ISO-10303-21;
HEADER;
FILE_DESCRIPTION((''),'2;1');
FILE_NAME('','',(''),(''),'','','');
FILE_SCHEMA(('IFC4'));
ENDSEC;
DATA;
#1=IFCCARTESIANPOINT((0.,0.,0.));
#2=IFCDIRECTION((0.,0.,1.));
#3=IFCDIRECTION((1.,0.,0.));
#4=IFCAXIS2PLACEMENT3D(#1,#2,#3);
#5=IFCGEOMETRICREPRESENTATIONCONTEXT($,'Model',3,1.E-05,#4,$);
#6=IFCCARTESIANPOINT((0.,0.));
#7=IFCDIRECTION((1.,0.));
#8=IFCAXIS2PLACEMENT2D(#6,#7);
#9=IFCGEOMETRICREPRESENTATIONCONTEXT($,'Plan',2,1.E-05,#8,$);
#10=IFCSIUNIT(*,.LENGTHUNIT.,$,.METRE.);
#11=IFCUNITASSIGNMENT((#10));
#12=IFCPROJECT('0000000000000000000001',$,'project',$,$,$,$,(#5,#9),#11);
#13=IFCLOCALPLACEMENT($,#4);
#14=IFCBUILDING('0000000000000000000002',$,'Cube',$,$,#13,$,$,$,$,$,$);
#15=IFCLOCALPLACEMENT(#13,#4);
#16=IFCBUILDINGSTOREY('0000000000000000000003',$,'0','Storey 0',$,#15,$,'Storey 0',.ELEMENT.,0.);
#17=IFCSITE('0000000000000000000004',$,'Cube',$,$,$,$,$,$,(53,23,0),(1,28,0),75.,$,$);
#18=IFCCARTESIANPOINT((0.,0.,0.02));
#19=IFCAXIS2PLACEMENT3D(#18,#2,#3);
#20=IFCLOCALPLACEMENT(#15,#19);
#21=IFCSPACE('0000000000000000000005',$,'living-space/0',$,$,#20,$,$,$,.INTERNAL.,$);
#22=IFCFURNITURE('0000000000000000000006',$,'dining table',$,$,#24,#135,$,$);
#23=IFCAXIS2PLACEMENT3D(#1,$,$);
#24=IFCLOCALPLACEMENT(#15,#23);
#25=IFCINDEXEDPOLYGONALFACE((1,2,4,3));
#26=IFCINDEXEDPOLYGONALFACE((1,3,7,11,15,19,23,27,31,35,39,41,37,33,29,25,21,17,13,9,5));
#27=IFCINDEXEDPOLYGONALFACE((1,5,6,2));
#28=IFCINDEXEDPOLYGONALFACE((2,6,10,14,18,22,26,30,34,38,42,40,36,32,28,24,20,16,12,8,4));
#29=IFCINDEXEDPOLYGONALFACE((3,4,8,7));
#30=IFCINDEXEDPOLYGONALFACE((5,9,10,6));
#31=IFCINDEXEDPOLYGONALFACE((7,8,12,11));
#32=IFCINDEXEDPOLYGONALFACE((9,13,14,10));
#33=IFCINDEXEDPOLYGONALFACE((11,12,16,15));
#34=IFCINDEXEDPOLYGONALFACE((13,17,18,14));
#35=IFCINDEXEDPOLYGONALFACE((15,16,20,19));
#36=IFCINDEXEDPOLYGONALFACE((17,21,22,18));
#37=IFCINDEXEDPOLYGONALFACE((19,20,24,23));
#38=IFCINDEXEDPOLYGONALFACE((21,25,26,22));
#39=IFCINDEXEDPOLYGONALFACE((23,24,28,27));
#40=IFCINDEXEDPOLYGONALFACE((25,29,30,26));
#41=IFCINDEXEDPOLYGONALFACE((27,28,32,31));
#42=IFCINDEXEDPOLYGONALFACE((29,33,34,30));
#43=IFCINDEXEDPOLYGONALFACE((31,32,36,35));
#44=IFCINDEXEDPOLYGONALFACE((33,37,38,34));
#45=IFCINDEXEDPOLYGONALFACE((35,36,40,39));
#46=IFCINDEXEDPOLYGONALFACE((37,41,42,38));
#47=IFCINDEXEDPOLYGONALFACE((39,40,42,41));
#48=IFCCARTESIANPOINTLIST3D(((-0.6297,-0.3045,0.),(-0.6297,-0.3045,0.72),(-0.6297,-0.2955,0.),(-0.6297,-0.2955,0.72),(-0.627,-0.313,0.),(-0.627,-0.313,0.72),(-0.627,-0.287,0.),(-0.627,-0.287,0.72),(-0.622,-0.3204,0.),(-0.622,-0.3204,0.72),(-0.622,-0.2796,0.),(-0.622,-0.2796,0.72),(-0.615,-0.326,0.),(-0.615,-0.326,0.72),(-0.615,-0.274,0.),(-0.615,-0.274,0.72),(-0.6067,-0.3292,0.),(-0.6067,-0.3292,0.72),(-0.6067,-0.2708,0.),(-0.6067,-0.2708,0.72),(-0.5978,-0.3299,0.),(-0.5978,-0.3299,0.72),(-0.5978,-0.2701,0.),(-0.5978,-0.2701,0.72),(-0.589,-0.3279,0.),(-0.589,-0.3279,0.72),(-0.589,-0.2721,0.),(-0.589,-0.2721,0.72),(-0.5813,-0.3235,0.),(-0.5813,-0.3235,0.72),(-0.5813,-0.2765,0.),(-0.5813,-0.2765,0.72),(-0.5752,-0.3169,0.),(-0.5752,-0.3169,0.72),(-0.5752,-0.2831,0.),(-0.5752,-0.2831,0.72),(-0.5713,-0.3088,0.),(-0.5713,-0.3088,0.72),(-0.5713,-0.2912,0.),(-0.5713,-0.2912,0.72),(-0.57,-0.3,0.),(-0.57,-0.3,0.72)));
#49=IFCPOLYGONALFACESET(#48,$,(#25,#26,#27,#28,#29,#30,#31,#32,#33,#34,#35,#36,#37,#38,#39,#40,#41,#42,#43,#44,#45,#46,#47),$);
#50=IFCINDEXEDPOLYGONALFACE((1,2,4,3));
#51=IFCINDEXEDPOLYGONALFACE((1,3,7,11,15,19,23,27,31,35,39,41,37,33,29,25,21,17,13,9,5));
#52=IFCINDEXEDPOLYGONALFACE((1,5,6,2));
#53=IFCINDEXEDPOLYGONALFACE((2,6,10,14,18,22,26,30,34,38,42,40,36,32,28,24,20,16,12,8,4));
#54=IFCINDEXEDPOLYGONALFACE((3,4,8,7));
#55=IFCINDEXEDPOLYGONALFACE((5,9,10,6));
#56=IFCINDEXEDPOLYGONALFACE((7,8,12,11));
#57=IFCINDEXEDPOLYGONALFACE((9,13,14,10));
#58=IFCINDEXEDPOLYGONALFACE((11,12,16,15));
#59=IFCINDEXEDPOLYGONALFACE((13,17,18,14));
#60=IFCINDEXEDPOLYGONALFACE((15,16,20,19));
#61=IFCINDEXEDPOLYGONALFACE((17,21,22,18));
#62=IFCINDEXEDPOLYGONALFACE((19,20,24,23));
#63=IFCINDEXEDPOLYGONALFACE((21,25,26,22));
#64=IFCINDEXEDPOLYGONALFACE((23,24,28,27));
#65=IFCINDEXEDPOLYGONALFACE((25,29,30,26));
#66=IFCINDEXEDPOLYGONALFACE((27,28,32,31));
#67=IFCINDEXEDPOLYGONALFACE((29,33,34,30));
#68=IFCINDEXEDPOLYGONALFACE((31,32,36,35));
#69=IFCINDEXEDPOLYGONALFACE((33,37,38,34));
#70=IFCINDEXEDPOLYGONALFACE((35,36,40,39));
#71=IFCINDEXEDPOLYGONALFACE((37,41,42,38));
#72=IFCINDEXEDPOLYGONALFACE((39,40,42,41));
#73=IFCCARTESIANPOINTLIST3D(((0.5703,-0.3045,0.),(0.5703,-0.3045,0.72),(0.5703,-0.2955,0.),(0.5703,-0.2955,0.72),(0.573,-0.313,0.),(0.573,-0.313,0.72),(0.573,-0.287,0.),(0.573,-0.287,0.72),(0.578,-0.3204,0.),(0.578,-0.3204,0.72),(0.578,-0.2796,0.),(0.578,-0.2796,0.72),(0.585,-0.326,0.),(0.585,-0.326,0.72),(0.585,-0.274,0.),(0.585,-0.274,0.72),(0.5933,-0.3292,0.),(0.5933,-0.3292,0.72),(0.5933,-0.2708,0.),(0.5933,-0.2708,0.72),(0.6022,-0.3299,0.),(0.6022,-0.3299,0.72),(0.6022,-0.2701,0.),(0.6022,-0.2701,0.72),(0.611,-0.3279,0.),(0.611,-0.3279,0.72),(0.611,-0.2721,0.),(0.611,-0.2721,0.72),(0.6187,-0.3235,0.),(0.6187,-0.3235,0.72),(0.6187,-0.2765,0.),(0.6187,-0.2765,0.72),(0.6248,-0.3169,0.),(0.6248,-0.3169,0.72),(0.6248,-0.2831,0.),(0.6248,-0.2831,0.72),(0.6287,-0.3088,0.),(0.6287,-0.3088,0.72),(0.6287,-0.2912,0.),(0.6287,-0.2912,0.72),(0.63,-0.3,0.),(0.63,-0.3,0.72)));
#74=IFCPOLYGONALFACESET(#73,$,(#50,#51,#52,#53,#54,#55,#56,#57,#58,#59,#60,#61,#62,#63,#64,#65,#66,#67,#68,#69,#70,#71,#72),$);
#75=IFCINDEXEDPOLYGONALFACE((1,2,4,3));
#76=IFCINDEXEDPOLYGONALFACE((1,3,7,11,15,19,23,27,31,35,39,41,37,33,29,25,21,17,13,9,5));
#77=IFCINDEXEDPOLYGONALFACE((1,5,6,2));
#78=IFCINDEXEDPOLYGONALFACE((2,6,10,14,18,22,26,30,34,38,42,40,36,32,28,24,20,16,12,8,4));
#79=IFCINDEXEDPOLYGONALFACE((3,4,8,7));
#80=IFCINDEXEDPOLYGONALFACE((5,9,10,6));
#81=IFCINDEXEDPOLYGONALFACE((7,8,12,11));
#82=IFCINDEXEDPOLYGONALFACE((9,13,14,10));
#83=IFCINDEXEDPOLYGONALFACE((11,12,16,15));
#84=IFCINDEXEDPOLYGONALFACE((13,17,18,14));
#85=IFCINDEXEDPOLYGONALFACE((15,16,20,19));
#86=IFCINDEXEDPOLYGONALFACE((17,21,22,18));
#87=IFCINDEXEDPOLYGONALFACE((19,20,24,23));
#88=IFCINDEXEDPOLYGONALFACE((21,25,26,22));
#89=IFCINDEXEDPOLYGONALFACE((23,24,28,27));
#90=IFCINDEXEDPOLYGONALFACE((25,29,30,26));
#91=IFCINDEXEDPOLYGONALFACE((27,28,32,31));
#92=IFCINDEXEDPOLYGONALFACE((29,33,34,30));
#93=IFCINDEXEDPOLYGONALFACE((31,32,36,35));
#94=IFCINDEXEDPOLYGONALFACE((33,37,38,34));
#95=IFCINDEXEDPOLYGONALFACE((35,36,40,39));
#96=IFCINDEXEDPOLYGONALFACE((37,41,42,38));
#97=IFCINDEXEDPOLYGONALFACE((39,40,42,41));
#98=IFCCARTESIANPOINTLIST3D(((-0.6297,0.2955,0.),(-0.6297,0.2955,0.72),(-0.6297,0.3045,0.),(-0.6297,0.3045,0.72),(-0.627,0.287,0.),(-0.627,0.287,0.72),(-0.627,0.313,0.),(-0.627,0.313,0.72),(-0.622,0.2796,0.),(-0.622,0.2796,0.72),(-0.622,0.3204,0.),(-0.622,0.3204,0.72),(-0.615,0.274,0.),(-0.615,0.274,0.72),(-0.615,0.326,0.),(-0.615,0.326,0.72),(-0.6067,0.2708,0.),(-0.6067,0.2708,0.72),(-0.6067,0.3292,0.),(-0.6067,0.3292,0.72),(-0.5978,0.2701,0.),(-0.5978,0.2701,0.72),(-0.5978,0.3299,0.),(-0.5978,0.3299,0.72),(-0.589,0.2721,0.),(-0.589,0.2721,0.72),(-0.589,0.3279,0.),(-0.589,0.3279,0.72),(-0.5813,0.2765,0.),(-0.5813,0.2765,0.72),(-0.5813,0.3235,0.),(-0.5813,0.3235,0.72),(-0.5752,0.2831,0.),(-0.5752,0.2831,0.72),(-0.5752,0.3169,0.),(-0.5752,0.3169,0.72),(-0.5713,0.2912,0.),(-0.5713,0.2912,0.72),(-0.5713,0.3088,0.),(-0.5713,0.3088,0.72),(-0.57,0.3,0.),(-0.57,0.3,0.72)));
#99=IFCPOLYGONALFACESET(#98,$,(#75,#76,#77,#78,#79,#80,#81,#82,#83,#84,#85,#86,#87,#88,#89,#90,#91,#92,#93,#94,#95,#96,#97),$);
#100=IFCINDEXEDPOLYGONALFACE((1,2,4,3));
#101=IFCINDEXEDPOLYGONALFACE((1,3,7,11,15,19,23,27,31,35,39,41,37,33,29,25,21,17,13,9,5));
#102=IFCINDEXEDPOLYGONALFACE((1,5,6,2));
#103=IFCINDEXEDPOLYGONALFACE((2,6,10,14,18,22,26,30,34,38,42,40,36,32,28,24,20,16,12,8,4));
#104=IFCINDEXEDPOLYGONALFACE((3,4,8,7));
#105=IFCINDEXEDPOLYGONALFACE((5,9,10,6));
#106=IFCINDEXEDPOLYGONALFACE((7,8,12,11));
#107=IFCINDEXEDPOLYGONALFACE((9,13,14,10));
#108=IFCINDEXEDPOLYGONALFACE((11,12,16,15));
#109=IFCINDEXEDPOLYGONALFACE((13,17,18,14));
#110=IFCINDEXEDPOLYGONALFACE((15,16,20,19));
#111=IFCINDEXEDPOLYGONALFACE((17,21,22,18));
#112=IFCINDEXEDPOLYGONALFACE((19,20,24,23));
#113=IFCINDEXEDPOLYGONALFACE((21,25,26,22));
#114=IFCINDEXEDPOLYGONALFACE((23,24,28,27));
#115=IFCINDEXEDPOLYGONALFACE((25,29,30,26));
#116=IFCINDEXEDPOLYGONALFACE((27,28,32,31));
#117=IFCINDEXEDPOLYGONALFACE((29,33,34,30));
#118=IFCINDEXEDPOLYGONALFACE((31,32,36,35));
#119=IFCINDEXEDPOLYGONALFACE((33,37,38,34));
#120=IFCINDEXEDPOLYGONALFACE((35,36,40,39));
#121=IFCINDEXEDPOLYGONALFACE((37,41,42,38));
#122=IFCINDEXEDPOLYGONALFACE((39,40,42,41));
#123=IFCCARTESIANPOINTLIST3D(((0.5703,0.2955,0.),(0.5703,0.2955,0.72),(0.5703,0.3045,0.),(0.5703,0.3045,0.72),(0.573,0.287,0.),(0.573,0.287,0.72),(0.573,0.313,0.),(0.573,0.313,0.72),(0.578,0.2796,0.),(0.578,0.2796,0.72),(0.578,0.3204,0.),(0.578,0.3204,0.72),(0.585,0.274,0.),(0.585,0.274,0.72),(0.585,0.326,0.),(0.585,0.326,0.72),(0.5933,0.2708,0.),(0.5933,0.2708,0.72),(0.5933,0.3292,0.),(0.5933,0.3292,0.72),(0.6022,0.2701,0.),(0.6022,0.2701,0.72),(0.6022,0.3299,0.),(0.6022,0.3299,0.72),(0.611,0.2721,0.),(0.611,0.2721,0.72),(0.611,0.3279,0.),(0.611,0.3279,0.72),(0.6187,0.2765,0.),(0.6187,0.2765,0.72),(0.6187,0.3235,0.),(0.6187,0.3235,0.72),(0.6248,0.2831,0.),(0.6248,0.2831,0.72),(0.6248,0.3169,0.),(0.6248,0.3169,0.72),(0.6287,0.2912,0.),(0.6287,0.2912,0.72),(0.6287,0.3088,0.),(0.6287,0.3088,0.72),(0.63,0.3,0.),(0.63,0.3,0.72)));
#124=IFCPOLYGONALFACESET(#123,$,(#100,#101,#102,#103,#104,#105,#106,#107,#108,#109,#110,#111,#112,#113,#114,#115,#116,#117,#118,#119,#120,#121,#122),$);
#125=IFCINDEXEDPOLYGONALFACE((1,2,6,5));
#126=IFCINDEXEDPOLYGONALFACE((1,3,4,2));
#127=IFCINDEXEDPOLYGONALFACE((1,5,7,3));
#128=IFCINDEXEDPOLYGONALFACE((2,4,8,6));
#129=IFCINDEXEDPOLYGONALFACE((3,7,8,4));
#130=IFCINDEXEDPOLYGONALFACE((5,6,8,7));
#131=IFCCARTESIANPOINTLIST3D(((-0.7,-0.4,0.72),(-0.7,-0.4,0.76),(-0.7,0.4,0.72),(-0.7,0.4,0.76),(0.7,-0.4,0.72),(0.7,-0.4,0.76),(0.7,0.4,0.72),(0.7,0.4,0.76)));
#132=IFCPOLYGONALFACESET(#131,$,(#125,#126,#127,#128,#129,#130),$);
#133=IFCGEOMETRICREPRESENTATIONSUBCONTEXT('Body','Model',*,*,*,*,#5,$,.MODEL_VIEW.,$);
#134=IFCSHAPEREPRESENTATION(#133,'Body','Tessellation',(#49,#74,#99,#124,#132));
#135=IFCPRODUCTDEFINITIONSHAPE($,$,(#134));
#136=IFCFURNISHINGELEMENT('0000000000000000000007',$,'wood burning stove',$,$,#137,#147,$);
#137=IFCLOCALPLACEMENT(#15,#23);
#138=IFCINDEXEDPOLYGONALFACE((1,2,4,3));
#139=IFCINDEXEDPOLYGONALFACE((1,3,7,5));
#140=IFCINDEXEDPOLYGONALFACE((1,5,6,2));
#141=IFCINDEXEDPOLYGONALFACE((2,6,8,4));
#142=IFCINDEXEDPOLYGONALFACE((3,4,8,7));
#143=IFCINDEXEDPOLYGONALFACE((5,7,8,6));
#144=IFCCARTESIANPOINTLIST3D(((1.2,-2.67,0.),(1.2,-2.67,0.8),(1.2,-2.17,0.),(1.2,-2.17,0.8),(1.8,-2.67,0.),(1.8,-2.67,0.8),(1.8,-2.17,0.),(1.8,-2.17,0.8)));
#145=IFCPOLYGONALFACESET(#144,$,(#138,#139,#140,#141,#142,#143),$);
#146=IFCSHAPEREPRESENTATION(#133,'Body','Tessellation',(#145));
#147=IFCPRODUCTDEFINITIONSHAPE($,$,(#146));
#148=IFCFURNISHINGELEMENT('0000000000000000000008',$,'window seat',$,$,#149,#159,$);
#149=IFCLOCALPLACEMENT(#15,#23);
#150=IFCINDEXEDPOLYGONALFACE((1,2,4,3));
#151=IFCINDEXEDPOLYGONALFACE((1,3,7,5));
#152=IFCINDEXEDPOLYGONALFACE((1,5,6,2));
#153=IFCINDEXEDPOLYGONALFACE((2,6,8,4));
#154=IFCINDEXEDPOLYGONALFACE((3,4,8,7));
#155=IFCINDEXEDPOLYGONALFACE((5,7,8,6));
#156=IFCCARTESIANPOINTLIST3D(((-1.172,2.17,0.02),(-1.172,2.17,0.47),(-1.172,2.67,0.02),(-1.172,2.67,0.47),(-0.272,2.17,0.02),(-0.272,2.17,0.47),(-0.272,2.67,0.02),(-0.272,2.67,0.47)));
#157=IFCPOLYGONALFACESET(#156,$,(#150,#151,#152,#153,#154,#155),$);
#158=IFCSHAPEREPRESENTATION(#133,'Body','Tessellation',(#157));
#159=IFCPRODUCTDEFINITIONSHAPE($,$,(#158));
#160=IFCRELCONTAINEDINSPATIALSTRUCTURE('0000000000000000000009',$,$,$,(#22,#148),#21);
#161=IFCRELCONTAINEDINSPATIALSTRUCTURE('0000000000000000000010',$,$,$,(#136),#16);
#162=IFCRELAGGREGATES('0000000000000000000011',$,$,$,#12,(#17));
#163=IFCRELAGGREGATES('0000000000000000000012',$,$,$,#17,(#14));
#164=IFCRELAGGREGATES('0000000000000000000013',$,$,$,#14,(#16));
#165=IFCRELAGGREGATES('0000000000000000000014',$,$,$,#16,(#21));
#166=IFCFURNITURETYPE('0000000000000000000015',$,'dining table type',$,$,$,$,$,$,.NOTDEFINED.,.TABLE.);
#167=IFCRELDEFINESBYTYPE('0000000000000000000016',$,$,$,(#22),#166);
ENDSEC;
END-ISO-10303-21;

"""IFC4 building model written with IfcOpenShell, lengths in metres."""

from ifc_helpers import new_model, entity, si_unit, frame, origin_with_axes, origin_2d_with_axis, place, context, subcontext, project, spatial, indexed_curve, outline, extrude, source, transform, mapped, type_object, type_shapes, element, save


model = new_model("IFC4")

# Units and contexts
model_context = context("Model", 3, precision=1e-05, world=origin_with_axes())
plan_context = context("Plan", 2, precision=1e-05, world=origin_2d_with_axis())
body_context = subcontext(model_context, "Body", "Model", "MODEL_VIEW")
ifc_project = project(units=[si_unit("LENGTHUNIT", "METRE")], contexts=[model_context, plan_context])

# Site, building, storey
site = spatial("IfcSite", under=ifc_project, Name="Cube", RefLatitude=(53, 23, 0), RefLongitude=(1, 28, 0), RefElevation=75.0)
building_placement = place(None, origin_with_axes())
building = spatial("IfcBuilding", under=site, at=building_placement, Name="Cube")
storey_placement = place(building_placement, origin_with_axes())
storey = spatial("IfcBuildingStorey", under=building, at=storey_placement, Name="0", Description="Storey 0", LongName="Storey 0", CompositionType="ELEMENT", Elevation=0.0)

# Shared definitions
space_placement = place(storey_placement, frame((0.0, 0.0, 0.02), z_axis=(0.0, 0.0, 1.0), x_axis=(1.0, 0.0, 0.0)))
space = spatial("IfcSpace", under=storey, at=space_placement, Name="living-space/0", PredefinedType="INTERNAL")

# Furniture
furniture_type = type_object("IfcFurnitureType", Name="dining table type", AssemblyPlace="NOTDEFINED", PredefinedType="TABLE")
shared_circle = entity("IfcCircle", entity("IfcAxis2Placement2D", entity("IfcCartesianPoint", [0.0, 0.0])), 0.03)
shared_shape_1 = source(origin_with_axes(), body_context, "Body", None, [
    entity("IfcExtrudedAreaSolid", entity("IfcArbitraryClosedProfileDef", "AREA", None, shared_circle), entity("IfcAxis2Placement3D", entity("IfcCartesianPoint", [-0.6, -0.3, 0.0]), entity("IfcDirection", [0.0, 0.0, 1.0]), entity("IfcDirection", [1.0, 0.0, 0.0])), entity("IfcDirection", [0.0, 0.0, 1.0]), 0.72),
    entity("IfcExtrudedAreaSolid", entity("IfcArbitraryClosedProfileDef", "AREA", None, shared_circle), entity("IfcAxis2Placement3D", entity("IfcCartesianPoint", [0.6, -0.3, 0.0]), entity("IfcDirection", [0.0, 0.0, 1.0]), entity("IfcDirection", [1.0, 0.0, 0.0])), entity("IfcDirection", [0.0, 0.0, 1.0]), 0.72),
    entity("IfcExtrudedAreaSolid", entity("IfcArbitraryClosedProfileDef", "AREA", None, shared_circle), entity("IfcAxis2Placement3D", entity("IfcCartesianPoint", [-0.6, 0.3, 0.0]), entity("IfcDirection", [0.0, 0.0, 1.0]), entity("IfcDirection", [1.0, 0.0, 0.0])), entity("IfcDirection", [0.0, 0.0, 1.0]), 0.72),
    entity("IfcExtrudedAreaSolid", entity("IfcArbitraryClosedProfileDef", "AREA", None, shared_circle), entity("IfcAxis2Placement3D", entity("IfcCartesianPoint", [0.6, 0.3, 0.0]), entity("IfcDirection", [0.0, 0.0, 1.0]), entity("IfcDirection", [1.0, 0.0, 0.0])), entity("IfcDirection", [0.0, 0.0, 1.0]), 0.72),
    entity("IfcBlock", entity("IfcAxis2Placement3D", entity("IfcCartesianPoint", [-0.7, -0.4, 0.72]), entity("IfcDirection", [0.0, 0.0, 1.0]), entity("IfcDirection", [1.0, 0.0, 0.0])), 1.4, 0.8, 0.04),
])
type_shapes(furniture_type, [shared_shape_1])
furniture_placement = place(space_placement, frame((0.0, 0.0, -0.02), z_axis=(0.0, 0.0, 1.0), x_axis=(1.0, 0.0, 0.0)))
element("IfcFurniture", 1, at=furniture_placement, inside=space, type_object=furniture_type, Name="dining table", context=body_context, shape_type="MappedRepresentation", body=[
    mapped(shared_shape_1, transform((0.0, 0.0, 0.0), x_axis=(1.0, 0.0, 0.0), y_axis=(0.0, 1.0, 0.0), z_axis=(0.0, 0.0, 1.0), scale=1.0)),
])

# Furnishing elements
furnishing_1_placement = place(storey_placement, frame((1.2, -2.67, 0.0), z_axis=(0.0, 0.0, 1.0), x_axis=(1.0, 0.0, 0.0)))
element("IfcFurnishingElement", 2, at=furnishing_1_placement, inside=storey, Name="wood burning stove", context=body_context, shape_type="SweptSolid", body=[
    extrude(outline(indexed_curve([(0.0, 0.0), (0.6, 0.0), (0.6, 0.5), (0.0, 0.5)])), None, (0.0, 0.0, 1.0), 0.8),
])
furnishing_2_placement = place(space_placement, frame((-1.172, 2.17, 0.0), z_axis=(0.0, 0.0, 1.0), x_axis=(1.0, 0.0, 0.0)))
element("IfcFurnishingElement", 3, at=furnishing_2_placement, inside=space, Name="window seat", context=body_context, shape_type="SweptSolid", body=[
    extrude(outline(indexed_curve([(0.0, 0.0), (0.9, 0.0), (0.9, 0.5), (0.0, 0.5)])), None, (0.0, 0.0, 1.0), 0.45),
])

save(model, "model.ifc")
